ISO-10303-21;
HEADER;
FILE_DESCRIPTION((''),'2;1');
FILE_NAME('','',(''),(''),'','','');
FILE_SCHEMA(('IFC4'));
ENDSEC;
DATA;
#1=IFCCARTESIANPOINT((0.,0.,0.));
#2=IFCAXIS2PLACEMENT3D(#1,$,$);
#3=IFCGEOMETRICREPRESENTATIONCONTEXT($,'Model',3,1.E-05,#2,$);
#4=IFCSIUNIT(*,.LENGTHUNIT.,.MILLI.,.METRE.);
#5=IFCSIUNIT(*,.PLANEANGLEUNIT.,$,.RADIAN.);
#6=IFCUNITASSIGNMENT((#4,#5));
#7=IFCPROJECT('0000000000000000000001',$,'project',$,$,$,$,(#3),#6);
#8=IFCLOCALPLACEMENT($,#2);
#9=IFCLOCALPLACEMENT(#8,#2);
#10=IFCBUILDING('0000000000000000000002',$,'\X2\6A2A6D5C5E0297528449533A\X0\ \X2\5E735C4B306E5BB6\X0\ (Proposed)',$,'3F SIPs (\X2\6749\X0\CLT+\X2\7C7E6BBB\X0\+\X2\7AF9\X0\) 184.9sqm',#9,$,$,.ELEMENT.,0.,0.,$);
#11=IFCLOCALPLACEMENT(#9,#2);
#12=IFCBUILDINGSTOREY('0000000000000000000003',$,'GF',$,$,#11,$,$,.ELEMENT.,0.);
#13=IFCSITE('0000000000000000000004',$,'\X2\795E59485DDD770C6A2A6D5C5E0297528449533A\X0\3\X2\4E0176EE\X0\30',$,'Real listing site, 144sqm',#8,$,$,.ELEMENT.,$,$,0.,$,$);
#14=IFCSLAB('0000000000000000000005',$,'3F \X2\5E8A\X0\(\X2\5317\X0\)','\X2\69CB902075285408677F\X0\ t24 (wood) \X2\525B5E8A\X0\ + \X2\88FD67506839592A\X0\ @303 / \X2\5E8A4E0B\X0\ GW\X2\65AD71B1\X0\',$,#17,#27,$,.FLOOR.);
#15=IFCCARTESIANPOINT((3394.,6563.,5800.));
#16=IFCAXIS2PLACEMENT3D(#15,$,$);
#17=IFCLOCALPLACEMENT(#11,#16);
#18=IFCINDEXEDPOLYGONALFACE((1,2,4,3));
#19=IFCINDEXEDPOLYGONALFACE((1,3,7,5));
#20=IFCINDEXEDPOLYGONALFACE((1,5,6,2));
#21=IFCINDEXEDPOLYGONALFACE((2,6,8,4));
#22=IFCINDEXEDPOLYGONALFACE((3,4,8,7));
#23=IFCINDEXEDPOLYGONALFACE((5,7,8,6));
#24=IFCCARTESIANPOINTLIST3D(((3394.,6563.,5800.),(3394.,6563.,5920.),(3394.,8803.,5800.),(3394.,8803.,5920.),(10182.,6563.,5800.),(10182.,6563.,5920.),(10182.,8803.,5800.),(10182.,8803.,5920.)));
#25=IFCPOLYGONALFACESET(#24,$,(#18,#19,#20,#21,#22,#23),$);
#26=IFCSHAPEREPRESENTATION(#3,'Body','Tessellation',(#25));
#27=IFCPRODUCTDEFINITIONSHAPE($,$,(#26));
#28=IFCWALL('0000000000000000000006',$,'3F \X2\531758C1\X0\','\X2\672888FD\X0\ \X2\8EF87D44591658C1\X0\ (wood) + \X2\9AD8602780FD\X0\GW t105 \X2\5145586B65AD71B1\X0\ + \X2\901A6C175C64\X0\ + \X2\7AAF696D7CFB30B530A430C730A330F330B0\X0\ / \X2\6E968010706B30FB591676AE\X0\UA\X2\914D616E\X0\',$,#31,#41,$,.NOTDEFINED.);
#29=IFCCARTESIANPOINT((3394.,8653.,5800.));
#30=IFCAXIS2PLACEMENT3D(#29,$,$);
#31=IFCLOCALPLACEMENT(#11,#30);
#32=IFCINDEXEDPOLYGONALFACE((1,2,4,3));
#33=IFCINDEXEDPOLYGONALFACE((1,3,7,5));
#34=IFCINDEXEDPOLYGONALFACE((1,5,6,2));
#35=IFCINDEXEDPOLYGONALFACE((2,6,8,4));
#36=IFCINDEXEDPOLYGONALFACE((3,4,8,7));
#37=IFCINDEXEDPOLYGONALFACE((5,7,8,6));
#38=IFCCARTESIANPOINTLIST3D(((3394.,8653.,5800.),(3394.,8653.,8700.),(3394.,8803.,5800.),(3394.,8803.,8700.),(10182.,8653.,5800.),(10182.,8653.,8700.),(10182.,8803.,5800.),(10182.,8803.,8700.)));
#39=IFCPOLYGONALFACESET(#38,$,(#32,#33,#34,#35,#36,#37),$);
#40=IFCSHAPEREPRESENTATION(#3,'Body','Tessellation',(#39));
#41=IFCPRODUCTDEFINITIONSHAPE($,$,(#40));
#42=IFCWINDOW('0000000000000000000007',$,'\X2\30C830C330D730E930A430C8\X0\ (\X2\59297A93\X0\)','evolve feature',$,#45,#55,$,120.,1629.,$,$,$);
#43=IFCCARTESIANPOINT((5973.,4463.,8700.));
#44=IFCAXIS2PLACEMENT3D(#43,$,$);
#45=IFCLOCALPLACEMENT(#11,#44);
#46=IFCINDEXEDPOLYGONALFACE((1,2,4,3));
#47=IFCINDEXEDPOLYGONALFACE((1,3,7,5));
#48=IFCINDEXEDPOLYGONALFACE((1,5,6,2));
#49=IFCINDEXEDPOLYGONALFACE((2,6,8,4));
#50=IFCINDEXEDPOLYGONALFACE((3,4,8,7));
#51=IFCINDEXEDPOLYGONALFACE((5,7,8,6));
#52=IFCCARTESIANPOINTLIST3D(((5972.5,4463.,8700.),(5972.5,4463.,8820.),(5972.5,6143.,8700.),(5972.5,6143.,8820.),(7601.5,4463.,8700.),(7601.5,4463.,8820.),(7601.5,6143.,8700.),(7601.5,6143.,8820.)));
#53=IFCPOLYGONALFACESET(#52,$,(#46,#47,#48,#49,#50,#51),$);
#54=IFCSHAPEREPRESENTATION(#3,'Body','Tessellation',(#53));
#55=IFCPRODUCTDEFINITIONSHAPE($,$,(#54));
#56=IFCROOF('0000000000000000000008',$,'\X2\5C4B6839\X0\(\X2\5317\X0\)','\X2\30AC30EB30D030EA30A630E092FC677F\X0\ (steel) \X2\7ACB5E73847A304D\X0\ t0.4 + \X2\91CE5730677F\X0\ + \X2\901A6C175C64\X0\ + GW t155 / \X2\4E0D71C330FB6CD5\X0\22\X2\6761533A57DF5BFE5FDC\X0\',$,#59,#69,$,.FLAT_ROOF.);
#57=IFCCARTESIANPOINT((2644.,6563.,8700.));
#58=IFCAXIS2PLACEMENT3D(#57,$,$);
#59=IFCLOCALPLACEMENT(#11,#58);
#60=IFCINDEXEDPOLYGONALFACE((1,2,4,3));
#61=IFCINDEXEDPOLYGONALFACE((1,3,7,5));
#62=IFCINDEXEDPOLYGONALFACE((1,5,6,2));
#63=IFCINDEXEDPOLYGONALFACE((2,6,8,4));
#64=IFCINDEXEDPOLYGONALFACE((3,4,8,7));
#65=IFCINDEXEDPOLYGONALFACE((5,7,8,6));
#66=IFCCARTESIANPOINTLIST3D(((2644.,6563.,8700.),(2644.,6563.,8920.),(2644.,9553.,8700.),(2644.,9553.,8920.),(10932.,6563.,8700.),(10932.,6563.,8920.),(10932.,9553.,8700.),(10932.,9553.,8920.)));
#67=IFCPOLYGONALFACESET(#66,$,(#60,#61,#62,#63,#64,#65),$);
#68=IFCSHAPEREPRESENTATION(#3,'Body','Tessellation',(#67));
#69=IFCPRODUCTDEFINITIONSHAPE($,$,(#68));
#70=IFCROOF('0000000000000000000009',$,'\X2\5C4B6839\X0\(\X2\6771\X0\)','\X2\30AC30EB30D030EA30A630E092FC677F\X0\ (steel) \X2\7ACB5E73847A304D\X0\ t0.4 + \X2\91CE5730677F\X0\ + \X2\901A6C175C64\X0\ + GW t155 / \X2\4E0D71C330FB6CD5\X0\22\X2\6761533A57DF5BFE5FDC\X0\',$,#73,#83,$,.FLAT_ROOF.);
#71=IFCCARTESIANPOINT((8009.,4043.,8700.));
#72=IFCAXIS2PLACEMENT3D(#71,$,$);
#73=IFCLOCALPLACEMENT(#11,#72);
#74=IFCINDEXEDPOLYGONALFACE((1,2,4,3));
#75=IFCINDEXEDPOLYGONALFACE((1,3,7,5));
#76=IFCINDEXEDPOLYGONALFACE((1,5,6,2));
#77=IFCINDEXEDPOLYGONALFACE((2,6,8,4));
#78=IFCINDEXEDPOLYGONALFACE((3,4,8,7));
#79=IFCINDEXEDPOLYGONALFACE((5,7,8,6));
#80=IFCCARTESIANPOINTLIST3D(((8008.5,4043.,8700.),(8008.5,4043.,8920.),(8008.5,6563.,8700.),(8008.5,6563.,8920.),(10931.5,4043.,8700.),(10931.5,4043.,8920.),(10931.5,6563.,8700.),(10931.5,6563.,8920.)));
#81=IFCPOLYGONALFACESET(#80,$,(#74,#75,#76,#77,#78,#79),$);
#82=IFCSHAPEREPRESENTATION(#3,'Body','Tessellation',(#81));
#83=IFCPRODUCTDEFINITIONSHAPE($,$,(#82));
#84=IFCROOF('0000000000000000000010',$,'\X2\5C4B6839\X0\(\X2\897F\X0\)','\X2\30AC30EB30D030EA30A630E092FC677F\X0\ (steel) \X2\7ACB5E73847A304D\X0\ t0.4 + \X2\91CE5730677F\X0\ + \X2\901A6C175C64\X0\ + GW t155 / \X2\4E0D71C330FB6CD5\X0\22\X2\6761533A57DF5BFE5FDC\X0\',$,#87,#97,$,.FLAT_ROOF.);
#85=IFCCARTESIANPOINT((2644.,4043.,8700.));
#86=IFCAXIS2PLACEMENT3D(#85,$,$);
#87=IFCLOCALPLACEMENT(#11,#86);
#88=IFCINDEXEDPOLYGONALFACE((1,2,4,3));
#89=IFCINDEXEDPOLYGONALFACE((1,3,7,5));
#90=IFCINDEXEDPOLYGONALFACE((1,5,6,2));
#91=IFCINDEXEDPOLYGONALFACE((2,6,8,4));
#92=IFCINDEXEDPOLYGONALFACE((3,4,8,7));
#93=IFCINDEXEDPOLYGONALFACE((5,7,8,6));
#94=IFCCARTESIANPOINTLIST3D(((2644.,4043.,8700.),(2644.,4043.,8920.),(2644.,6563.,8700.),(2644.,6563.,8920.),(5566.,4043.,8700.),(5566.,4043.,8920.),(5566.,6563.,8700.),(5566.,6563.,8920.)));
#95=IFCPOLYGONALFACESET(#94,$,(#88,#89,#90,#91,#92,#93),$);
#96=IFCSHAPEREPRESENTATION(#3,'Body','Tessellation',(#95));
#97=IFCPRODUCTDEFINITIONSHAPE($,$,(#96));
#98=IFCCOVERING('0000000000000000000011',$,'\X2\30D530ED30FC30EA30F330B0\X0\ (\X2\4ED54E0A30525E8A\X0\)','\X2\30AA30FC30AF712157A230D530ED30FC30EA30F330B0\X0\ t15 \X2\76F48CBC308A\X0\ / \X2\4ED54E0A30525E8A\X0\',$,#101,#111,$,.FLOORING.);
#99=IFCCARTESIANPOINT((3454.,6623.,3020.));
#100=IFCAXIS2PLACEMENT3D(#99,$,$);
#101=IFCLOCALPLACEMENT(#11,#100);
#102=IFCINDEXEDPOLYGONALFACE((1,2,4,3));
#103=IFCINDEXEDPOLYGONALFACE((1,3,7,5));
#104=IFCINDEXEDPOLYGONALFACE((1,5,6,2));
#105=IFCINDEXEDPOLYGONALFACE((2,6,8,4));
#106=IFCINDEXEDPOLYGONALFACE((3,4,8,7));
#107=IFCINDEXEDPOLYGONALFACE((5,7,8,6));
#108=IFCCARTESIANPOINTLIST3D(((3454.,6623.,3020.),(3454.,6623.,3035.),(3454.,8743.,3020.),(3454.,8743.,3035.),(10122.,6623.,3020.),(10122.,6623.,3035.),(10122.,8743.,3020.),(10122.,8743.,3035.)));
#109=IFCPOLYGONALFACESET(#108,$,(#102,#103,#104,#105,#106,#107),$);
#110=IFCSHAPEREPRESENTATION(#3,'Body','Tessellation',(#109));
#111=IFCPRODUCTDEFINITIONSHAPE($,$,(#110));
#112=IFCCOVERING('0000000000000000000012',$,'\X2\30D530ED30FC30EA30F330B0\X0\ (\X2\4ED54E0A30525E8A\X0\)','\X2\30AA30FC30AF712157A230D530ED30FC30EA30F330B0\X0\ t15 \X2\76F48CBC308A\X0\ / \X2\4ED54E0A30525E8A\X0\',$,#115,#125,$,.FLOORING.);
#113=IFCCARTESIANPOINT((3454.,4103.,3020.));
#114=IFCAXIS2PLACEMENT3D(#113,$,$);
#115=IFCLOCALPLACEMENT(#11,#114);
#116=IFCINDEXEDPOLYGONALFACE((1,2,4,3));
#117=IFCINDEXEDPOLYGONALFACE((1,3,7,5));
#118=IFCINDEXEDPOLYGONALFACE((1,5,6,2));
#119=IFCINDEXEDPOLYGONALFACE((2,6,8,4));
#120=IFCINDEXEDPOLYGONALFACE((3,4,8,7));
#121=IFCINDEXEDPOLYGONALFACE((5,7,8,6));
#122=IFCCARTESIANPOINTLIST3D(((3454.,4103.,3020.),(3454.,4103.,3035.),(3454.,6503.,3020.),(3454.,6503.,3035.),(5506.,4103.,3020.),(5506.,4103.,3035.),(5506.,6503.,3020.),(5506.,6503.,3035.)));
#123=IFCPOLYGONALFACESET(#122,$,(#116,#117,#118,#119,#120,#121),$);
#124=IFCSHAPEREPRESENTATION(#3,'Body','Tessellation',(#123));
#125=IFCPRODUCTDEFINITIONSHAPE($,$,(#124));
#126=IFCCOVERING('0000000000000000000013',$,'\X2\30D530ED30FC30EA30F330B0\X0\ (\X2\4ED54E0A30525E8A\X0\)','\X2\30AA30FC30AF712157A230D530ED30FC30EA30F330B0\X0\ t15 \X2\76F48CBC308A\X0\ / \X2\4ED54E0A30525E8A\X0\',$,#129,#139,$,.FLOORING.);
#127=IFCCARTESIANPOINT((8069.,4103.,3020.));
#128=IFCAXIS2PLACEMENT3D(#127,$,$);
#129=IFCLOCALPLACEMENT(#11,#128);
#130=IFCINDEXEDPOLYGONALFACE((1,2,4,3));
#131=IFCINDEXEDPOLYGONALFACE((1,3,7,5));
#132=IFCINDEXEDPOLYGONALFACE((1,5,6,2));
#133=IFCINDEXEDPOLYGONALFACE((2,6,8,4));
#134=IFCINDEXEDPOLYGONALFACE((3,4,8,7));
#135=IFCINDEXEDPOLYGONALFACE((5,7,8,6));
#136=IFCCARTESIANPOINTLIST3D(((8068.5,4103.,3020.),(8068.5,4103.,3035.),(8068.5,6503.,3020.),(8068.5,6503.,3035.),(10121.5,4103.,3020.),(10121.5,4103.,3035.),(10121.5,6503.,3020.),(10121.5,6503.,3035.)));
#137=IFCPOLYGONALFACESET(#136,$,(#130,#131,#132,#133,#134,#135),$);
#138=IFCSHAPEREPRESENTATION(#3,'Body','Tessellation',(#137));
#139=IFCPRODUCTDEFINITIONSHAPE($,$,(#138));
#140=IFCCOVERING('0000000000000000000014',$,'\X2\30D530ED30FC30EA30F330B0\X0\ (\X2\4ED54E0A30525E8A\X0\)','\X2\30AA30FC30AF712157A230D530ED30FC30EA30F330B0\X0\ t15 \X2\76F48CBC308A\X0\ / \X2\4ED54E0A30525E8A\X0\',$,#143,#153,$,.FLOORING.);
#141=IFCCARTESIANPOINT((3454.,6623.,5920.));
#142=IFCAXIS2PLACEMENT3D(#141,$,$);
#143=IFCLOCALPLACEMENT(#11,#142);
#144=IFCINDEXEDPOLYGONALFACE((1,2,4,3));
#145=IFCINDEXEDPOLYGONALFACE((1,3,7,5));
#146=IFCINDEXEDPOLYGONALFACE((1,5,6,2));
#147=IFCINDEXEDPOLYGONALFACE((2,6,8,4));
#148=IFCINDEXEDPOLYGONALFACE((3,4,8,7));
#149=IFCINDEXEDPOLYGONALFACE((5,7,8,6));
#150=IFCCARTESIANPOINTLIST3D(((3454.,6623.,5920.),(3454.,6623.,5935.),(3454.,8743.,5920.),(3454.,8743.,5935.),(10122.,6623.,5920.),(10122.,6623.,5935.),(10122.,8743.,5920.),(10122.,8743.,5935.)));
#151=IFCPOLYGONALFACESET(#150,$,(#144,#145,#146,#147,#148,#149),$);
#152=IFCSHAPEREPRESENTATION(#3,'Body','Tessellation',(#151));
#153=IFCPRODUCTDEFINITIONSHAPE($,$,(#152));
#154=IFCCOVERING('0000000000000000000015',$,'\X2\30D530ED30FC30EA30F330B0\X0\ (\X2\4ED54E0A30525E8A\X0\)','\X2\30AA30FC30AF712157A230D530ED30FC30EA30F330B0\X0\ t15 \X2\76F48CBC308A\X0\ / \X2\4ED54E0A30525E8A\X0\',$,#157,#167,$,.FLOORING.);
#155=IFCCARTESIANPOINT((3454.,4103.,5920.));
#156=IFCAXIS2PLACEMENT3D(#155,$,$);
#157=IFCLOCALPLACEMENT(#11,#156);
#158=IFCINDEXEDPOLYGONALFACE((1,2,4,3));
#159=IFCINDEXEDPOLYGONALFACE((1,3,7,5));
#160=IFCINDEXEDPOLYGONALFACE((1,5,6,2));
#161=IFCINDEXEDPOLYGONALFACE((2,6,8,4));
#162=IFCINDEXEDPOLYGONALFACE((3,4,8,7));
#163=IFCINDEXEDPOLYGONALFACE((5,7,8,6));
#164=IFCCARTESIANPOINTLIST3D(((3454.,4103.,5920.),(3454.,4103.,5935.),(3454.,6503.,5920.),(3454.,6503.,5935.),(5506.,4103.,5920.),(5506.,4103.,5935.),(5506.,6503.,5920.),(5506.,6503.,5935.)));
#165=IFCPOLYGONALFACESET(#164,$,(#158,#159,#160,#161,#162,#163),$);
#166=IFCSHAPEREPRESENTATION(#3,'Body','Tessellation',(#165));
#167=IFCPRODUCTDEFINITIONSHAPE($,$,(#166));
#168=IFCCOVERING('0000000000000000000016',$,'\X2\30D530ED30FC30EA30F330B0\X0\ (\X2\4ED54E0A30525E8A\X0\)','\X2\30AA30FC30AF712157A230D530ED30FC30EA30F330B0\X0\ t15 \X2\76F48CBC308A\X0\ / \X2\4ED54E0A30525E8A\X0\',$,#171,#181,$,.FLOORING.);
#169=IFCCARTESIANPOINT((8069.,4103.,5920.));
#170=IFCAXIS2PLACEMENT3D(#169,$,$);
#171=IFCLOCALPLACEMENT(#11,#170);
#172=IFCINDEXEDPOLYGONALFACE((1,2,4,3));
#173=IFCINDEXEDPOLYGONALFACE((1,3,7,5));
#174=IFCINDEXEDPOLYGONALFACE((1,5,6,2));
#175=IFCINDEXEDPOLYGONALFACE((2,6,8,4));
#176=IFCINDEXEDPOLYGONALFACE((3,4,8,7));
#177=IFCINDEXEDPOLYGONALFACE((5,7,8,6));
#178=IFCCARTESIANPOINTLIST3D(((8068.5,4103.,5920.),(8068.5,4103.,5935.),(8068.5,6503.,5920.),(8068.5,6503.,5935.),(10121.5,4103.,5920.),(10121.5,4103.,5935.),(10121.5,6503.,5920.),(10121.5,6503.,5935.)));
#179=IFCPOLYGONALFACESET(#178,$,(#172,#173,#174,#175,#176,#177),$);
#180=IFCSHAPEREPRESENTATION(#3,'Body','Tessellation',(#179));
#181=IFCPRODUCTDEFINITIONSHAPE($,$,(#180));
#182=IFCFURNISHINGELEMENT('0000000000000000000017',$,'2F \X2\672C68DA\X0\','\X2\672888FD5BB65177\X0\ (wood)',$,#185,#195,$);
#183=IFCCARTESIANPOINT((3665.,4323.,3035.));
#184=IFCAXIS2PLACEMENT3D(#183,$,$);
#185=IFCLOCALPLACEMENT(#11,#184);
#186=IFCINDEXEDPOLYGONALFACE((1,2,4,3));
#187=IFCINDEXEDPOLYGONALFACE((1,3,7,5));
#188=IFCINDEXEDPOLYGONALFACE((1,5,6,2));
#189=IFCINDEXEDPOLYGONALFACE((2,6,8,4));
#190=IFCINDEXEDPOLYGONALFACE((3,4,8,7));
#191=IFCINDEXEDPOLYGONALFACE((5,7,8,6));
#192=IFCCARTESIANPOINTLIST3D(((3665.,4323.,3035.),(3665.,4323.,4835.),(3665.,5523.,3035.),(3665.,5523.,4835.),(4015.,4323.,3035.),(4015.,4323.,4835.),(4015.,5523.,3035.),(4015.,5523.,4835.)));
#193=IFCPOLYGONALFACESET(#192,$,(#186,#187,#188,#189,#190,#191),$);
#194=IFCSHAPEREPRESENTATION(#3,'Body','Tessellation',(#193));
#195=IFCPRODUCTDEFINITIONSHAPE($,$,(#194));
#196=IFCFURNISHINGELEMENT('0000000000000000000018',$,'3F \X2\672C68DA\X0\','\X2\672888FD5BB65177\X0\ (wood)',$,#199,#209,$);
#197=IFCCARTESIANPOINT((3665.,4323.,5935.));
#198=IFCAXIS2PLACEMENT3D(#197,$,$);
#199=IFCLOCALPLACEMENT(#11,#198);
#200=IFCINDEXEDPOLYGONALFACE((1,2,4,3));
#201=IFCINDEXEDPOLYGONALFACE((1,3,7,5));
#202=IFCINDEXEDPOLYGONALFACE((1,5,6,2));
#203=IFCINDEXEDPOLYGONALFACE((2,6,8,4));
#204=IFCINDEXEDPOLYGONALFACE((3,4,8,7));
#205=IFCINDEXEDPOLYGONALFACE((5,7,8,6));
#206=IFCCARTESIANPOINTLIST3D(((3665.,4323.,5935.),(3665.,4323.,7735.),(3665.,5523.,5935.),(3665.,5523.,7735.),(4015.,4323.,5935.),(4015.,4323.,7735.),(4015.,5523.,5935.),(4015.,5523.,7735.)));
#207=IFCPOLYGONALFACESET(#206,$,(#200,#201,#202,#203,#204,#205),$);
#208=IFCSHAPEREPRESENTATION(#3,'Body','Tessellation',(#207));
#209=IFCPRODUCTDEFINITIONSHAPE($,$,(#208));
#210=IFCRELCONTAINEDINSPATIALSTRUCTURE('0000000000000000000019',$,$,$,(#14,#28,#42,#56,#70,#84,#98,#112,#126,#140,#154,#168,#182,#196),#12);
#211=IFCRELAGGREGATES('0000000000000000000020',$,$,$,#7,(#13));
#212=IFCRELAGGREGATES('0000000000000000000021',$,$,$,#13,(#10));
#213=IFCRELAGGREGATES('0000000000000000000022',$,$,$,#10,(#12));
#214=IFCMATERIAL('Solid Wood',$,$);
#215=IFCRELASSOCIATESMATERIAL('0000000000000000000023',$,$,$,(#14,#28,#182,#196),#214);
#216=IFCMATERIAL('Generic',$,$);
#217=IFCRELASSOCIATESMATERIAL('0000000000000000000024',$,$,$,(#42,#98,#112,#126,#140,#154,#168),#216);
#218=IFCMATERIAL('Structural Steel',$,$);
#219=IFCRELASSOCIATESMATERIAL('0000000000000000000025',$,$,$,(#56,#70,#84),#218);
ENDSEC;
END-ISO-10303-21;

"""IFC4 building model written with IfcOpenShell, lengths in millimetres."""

from ifc_helpers import new_model, si_unit, frame, frame_2d, origin, place, context, project, spatial, rectangle, extrude, material, element, save


model = new_model("IFC4")

# Units and contexts
model_context = context("Model", 3, precision=1e-05, world=origin())
ifc_project = project(units=[si_unit("LENGTHUNIT", "METRE", prefix="MILLI"), si_unit("PLANEANGLEUNIT", "RADIAN")], contexts=[model_context])

# Site, building, storey
site_placement = place(None, origin())
site = spatial("IfcSite", under=ifc_project, at=site_placement, Name="神奈川県横浜市青葉区3丁目30", ObjectType="Real listing site, 144sqm", CompositionType="ELEMENT", RefElevation=0.0)
building_placement = place(site_placement, origin())
building = spatial("IfcBuilding", under=site, at=building_placement, Name="横浜市青葉区 平屋の家 (Proposed)", ObjectType="3F SIPs (杉CLT+籾殻+竹) 184.9sqm", CompositionType="ELEMENT", ElevationOfRefHeight=0.0, ElevationOfTerrain=0.0)
storey_placement = place(building_placement, origin())
storey = spatial("IfcBuildingStorey", under=building, at=storey_placement, Name="GF", CompositionType="ELEMENT", Elevation=0.0)

# Slab
ifc_material_1 = material(Name="Solid Wood")
slab_placement = place(storey_placement, frame((3394.0, 6563.0, 5800.0)))
element("IfcSlab", 1, at=slab_placement, inside=storey, material=ifc_material_1, Name="3F 床(北)", Description="構造用合板 t24 (wood) 剛床 + 製材根太 @303 / 床下 GW断熱", PredefinedType="FLOOR", context=model_context, shape_type="SweptSolid", body=[
    extrude(rectangle(XDim=6788.0, YDim=2240.0, at=frame_2d((3394.0, 1120.0))), frame((3394.0, 6563.0, 5800.0)), (0.0, 0.0, 1.0), 120.0),
])

# Wall
wall_1_placement = place(storey_placement, frame((3394.0, 8653.0, 5800.0)))
element("IfcWall", 2, at=wall_1_placement, inside=storey, material=ifc_material_1, Name="3F 北壁", Description="木製 軸組外壁 (wood) + 高性能GW t105 充填断熱 + 通気層 + 窯業系サイディング / 準耐火・外皮UA配慮", PredefinedType="NOTDEFINED", context=model_context, shape_type="SweptSolid", body=[
    extrude(rectangle(XDim=6788.0, YDim=150.0, at=frame_2d((3394.0, 75.0))), frame((3394.0, 8653.0, 5800.0)), (0.0, 0.0, 1.0), 2900.0),
])

# Window
ifc_material_2 = material(Name="Generic")
window_1_placement = place(storey_placement, frame((5973.0, 4463.0, 8700.0)))
element("IfcWindow", 3, at=window_1_placement, inside=storey, material=ifc_material_2, Name="トップライト (天窓)", Description="evolve feature", OverallHeight=120.0, OverallWidth=1629.0, context=model_context, shape_type="SweptSolid", body=[
    extrude(rectangle(XDim=1629.0, YDim=1680.0, at=frame_2d((814.0, 840.0))), frame((5973.0, 4463.0, 8700.0)), (0.0, 0.0, 1.0), 120.0),
])

# Roofs
ifc_material_3 = material(Name="Structural Steel")
roof_1_placement = place(storey_placement, frame((2644.0, 6563.0, 8700.0)))
element("IfcRoof", 4, at=roof_1_placement, inside=storey, material=ifc_material_3, Name="屋根(北)", Description="ガルバリウム鋼板 (steel) 立平葺き t0.4 + 野地板 + 通気層 + GW t155 / 不燃・法22条区域対応", PredefinedType="FLAT_ROOF", context=model_context, shape_type="SweptSolid", body=[
    extrude(rectangle(XDim=8288.0, YDim=2990.0, at=frame_2d((4144.0, 1495.0))), frame((2644.0, 6563.0, 8700.0)), (0.0, 0.0, 1.0), 220.0),
])
roof_2_placement = place(storey_placement, frame((8009.0, 4043.0, 8700.0)))
element("IfcRoof", 5, at=roof_2_placement, inside=storey, material=ifc_material_3, Name="屋根(東)", Description="ガルバリウム鋼板 (steel) 立平葺き t0.4 + 野地板 + 通気層 + GW t155 / 不燃・法22条区域対応", PredefinedType="FLAT_ROOF", context=model_context, shape_type="SweptSolid", body=[
    extrude(rectangle(XDim=2923.0, YDim=2520.0, at=frame_2d((1461.0, 1260.0))), frame((8009.0, 4043.0, 8700.0)), (0.0, 0.0, 1.0), 220.0),
])
roof_3_placement = place(storey_placement, frame((2644.0, 4043.0, 8700.0)))
element("IfcRoof", 6, at=roof_3_placement, inside=storey, material=ifc_material_3, Name="屋根(西)", Description="ガルバリウム鋼板 (steel) 立平葺き t0.4 + 野地板 + 通気層 + GW t155 / 不燃・法22条区域対応", PredefinedType="FLAT_ROOF", context=model_context, shape_type="SweptSolid", body=[
    extrude(rectangle(XDim=2922.0, YDim=2520.0, at=frame_2d((1461.0, 1260.0))), frame((2644.0, 4043.0, 8700.0)), (0.0, 0.0, 1.0), 220.0),
])

# Coverings
covering_1_placement = place(storey_placement, frame((3454.0, 6623.0, 3020.0)))
element("IfcCovering", 7, at=covering_1_placement, inside=storey, material=ifc_material_2, Name="フローリング (仕上げ床)", Description="オーク無垢フローリング t15 直貼り / 仕上げ床", PredefinedType="FLOORING", context=model_context, shape_type="SweptSolid", body=[
    extrude(rectangle(XDim=6668.0, YDim=2120.0, at=frame_2d((3334.0, 1060.0))), frame((3454.0, 6623.0, 3020.0)), (0.0, 0.0, 1.0), 15.0),
])
covering_2_placement = place(storey_placement, frame((3454.0, 4103.0, 3020.0)))
element("IfcCovering", 8, at=covering_2_placement, inside=storey, material=ifc_material_2, Name="フローリング (仕上げ床)", Description="オーク無垢フローリング t15 直貼り / 仕上げ床", PredefinedType="FLOORING", context=model_context, shape_type="SweptSolid", body=[
    extrude(rectangle(XDim=2052.0, YDim=2400.0, at=frame_2d((1026.0, 1200.0))), frame((3454.0, 4103.0, 3020.0)), (0.0, 0.0, 1.0), 15.0),
])
covering_3_placement = place(storey_placement, frame((8069.0, 4103.0, 3020.0)))
element("IfcCovering", 9, at=covering_3_placement, inside=storey, material=ifc_material_2, Name="フローリング (仕上げ床)", Description="オーク無垢フローリング t15 直貼り / 仕上げ床", PredefinedType="FLOORING", context=model_context, shape_type="SweptSolid", body=[
    extrude(rectangle(XDim=2053.0, YDim=2400.0, at=frame_2d((1026.0, 1200.0))), frame((8069.0, 4103.0, 3020.0)), (0.0, 0.0, 1.0), 15.0),
])
covering_4_placement = place(storey_placement, frame((3454.0, 6623.0, 5920.0)))
element("IfcCovering", 10, at=covering_4_placement, inside=storey, material=ifc_material_2, Name="フローリング (仕上げ床)", Description="オーク無垢フローリング t15 直貼り / 仕上げ床", PredefinedType="FLOORING", context=model_context, shape_type="SweptSolid", body=[
    extrude(rectangle(XDim=6668.0, YDim=2120.0, at=frame_2d((3334.0, 1060.0))), frame((3454.0, 6623.0, 5920.0)), (0.0, 0.0, 1.0), 15.0),
])
covering_5_placement = place(storey_placement, frame((3454.0, 4103.0, 5920.0)))
element("IfcCovering", 11, at=covering_5_placement, inside=storey, material=ifc_material_2, Name="フローリング (仕上げ床)", Description="オーク無垢フローリング t15 直貼り / 仕上げ床", PredefinedType="FLOORING", context=model_context, shape_type="SweptSolid", body=[
    extrude(rectangle(XDim=2052.0, YDim=2400.0, at=frame_2d((1026.0, 1200.0))), frame((3454.0, 4103.0, 5920.0)), (0.0, 0.0, 1.0), 15.0),
])
covering_6_placement = place(storey_placement, frame((8069.0, 4103.0, 5920.0)))
element("IfcCovering", 12, at=covering_6_placement, inside=storey, material=ifc_material_2, Name="フローリング (仕上げ床)", Description="オーク無垢フローリング t15 直貼り / 仕上げ床", PredefinedType="FLOORING", context=model_context, shape_type="SweptSolid", body=[
    extrude(rectangle(XDim=2053.0, YDim=2400.0, at=frame_2d((1026.0, 1200.0))), frame((8069.0, 4103.0, 5920.0)), (0.0, 0.0, 1.0), 15.0),
])

# Furnishing elements
furnishing_1_placement = place(storey_placement, frame((3665.0, 4323.0, 3035.0)))
element("IfcFurnishingElement", 13, at=furnishing_1_placement, inside=storey, material=ifc_material_1, Name="2F 本棚", Description="木製家具 (wood)", context=model_context, shape_type="SweptSolid", body=[
    extrude(rectangle(XDim=350.0, YDim=1200.0, at=frame_2d((175.0, 600.0))), frame((3665.0, 4323.0, 3035.0)), (0.0, 0.0, 1.0), 1800.0),
])
furnishing_2_placement = place(storey_placement, frame((3665.0, 4323.0, 5935.0)))
element("IfcFurnishingElement", 14, at=furnishing_2_placement, inside=storey, material=ifc_material_1, Name="3F 本棚", Description="木製家具 (wood)", context=model_context, shape_type="SweptSolid", body=[
    extrude(rectangle(XDim=350.0, YDim=1200.0, at=frame_2d((175.0, 600.0))), frame((3665.0, 4323.0, 5935.0)), (0.0, 0.0, 1.0), 1800.0),
])

save(model, "model.ifc")
